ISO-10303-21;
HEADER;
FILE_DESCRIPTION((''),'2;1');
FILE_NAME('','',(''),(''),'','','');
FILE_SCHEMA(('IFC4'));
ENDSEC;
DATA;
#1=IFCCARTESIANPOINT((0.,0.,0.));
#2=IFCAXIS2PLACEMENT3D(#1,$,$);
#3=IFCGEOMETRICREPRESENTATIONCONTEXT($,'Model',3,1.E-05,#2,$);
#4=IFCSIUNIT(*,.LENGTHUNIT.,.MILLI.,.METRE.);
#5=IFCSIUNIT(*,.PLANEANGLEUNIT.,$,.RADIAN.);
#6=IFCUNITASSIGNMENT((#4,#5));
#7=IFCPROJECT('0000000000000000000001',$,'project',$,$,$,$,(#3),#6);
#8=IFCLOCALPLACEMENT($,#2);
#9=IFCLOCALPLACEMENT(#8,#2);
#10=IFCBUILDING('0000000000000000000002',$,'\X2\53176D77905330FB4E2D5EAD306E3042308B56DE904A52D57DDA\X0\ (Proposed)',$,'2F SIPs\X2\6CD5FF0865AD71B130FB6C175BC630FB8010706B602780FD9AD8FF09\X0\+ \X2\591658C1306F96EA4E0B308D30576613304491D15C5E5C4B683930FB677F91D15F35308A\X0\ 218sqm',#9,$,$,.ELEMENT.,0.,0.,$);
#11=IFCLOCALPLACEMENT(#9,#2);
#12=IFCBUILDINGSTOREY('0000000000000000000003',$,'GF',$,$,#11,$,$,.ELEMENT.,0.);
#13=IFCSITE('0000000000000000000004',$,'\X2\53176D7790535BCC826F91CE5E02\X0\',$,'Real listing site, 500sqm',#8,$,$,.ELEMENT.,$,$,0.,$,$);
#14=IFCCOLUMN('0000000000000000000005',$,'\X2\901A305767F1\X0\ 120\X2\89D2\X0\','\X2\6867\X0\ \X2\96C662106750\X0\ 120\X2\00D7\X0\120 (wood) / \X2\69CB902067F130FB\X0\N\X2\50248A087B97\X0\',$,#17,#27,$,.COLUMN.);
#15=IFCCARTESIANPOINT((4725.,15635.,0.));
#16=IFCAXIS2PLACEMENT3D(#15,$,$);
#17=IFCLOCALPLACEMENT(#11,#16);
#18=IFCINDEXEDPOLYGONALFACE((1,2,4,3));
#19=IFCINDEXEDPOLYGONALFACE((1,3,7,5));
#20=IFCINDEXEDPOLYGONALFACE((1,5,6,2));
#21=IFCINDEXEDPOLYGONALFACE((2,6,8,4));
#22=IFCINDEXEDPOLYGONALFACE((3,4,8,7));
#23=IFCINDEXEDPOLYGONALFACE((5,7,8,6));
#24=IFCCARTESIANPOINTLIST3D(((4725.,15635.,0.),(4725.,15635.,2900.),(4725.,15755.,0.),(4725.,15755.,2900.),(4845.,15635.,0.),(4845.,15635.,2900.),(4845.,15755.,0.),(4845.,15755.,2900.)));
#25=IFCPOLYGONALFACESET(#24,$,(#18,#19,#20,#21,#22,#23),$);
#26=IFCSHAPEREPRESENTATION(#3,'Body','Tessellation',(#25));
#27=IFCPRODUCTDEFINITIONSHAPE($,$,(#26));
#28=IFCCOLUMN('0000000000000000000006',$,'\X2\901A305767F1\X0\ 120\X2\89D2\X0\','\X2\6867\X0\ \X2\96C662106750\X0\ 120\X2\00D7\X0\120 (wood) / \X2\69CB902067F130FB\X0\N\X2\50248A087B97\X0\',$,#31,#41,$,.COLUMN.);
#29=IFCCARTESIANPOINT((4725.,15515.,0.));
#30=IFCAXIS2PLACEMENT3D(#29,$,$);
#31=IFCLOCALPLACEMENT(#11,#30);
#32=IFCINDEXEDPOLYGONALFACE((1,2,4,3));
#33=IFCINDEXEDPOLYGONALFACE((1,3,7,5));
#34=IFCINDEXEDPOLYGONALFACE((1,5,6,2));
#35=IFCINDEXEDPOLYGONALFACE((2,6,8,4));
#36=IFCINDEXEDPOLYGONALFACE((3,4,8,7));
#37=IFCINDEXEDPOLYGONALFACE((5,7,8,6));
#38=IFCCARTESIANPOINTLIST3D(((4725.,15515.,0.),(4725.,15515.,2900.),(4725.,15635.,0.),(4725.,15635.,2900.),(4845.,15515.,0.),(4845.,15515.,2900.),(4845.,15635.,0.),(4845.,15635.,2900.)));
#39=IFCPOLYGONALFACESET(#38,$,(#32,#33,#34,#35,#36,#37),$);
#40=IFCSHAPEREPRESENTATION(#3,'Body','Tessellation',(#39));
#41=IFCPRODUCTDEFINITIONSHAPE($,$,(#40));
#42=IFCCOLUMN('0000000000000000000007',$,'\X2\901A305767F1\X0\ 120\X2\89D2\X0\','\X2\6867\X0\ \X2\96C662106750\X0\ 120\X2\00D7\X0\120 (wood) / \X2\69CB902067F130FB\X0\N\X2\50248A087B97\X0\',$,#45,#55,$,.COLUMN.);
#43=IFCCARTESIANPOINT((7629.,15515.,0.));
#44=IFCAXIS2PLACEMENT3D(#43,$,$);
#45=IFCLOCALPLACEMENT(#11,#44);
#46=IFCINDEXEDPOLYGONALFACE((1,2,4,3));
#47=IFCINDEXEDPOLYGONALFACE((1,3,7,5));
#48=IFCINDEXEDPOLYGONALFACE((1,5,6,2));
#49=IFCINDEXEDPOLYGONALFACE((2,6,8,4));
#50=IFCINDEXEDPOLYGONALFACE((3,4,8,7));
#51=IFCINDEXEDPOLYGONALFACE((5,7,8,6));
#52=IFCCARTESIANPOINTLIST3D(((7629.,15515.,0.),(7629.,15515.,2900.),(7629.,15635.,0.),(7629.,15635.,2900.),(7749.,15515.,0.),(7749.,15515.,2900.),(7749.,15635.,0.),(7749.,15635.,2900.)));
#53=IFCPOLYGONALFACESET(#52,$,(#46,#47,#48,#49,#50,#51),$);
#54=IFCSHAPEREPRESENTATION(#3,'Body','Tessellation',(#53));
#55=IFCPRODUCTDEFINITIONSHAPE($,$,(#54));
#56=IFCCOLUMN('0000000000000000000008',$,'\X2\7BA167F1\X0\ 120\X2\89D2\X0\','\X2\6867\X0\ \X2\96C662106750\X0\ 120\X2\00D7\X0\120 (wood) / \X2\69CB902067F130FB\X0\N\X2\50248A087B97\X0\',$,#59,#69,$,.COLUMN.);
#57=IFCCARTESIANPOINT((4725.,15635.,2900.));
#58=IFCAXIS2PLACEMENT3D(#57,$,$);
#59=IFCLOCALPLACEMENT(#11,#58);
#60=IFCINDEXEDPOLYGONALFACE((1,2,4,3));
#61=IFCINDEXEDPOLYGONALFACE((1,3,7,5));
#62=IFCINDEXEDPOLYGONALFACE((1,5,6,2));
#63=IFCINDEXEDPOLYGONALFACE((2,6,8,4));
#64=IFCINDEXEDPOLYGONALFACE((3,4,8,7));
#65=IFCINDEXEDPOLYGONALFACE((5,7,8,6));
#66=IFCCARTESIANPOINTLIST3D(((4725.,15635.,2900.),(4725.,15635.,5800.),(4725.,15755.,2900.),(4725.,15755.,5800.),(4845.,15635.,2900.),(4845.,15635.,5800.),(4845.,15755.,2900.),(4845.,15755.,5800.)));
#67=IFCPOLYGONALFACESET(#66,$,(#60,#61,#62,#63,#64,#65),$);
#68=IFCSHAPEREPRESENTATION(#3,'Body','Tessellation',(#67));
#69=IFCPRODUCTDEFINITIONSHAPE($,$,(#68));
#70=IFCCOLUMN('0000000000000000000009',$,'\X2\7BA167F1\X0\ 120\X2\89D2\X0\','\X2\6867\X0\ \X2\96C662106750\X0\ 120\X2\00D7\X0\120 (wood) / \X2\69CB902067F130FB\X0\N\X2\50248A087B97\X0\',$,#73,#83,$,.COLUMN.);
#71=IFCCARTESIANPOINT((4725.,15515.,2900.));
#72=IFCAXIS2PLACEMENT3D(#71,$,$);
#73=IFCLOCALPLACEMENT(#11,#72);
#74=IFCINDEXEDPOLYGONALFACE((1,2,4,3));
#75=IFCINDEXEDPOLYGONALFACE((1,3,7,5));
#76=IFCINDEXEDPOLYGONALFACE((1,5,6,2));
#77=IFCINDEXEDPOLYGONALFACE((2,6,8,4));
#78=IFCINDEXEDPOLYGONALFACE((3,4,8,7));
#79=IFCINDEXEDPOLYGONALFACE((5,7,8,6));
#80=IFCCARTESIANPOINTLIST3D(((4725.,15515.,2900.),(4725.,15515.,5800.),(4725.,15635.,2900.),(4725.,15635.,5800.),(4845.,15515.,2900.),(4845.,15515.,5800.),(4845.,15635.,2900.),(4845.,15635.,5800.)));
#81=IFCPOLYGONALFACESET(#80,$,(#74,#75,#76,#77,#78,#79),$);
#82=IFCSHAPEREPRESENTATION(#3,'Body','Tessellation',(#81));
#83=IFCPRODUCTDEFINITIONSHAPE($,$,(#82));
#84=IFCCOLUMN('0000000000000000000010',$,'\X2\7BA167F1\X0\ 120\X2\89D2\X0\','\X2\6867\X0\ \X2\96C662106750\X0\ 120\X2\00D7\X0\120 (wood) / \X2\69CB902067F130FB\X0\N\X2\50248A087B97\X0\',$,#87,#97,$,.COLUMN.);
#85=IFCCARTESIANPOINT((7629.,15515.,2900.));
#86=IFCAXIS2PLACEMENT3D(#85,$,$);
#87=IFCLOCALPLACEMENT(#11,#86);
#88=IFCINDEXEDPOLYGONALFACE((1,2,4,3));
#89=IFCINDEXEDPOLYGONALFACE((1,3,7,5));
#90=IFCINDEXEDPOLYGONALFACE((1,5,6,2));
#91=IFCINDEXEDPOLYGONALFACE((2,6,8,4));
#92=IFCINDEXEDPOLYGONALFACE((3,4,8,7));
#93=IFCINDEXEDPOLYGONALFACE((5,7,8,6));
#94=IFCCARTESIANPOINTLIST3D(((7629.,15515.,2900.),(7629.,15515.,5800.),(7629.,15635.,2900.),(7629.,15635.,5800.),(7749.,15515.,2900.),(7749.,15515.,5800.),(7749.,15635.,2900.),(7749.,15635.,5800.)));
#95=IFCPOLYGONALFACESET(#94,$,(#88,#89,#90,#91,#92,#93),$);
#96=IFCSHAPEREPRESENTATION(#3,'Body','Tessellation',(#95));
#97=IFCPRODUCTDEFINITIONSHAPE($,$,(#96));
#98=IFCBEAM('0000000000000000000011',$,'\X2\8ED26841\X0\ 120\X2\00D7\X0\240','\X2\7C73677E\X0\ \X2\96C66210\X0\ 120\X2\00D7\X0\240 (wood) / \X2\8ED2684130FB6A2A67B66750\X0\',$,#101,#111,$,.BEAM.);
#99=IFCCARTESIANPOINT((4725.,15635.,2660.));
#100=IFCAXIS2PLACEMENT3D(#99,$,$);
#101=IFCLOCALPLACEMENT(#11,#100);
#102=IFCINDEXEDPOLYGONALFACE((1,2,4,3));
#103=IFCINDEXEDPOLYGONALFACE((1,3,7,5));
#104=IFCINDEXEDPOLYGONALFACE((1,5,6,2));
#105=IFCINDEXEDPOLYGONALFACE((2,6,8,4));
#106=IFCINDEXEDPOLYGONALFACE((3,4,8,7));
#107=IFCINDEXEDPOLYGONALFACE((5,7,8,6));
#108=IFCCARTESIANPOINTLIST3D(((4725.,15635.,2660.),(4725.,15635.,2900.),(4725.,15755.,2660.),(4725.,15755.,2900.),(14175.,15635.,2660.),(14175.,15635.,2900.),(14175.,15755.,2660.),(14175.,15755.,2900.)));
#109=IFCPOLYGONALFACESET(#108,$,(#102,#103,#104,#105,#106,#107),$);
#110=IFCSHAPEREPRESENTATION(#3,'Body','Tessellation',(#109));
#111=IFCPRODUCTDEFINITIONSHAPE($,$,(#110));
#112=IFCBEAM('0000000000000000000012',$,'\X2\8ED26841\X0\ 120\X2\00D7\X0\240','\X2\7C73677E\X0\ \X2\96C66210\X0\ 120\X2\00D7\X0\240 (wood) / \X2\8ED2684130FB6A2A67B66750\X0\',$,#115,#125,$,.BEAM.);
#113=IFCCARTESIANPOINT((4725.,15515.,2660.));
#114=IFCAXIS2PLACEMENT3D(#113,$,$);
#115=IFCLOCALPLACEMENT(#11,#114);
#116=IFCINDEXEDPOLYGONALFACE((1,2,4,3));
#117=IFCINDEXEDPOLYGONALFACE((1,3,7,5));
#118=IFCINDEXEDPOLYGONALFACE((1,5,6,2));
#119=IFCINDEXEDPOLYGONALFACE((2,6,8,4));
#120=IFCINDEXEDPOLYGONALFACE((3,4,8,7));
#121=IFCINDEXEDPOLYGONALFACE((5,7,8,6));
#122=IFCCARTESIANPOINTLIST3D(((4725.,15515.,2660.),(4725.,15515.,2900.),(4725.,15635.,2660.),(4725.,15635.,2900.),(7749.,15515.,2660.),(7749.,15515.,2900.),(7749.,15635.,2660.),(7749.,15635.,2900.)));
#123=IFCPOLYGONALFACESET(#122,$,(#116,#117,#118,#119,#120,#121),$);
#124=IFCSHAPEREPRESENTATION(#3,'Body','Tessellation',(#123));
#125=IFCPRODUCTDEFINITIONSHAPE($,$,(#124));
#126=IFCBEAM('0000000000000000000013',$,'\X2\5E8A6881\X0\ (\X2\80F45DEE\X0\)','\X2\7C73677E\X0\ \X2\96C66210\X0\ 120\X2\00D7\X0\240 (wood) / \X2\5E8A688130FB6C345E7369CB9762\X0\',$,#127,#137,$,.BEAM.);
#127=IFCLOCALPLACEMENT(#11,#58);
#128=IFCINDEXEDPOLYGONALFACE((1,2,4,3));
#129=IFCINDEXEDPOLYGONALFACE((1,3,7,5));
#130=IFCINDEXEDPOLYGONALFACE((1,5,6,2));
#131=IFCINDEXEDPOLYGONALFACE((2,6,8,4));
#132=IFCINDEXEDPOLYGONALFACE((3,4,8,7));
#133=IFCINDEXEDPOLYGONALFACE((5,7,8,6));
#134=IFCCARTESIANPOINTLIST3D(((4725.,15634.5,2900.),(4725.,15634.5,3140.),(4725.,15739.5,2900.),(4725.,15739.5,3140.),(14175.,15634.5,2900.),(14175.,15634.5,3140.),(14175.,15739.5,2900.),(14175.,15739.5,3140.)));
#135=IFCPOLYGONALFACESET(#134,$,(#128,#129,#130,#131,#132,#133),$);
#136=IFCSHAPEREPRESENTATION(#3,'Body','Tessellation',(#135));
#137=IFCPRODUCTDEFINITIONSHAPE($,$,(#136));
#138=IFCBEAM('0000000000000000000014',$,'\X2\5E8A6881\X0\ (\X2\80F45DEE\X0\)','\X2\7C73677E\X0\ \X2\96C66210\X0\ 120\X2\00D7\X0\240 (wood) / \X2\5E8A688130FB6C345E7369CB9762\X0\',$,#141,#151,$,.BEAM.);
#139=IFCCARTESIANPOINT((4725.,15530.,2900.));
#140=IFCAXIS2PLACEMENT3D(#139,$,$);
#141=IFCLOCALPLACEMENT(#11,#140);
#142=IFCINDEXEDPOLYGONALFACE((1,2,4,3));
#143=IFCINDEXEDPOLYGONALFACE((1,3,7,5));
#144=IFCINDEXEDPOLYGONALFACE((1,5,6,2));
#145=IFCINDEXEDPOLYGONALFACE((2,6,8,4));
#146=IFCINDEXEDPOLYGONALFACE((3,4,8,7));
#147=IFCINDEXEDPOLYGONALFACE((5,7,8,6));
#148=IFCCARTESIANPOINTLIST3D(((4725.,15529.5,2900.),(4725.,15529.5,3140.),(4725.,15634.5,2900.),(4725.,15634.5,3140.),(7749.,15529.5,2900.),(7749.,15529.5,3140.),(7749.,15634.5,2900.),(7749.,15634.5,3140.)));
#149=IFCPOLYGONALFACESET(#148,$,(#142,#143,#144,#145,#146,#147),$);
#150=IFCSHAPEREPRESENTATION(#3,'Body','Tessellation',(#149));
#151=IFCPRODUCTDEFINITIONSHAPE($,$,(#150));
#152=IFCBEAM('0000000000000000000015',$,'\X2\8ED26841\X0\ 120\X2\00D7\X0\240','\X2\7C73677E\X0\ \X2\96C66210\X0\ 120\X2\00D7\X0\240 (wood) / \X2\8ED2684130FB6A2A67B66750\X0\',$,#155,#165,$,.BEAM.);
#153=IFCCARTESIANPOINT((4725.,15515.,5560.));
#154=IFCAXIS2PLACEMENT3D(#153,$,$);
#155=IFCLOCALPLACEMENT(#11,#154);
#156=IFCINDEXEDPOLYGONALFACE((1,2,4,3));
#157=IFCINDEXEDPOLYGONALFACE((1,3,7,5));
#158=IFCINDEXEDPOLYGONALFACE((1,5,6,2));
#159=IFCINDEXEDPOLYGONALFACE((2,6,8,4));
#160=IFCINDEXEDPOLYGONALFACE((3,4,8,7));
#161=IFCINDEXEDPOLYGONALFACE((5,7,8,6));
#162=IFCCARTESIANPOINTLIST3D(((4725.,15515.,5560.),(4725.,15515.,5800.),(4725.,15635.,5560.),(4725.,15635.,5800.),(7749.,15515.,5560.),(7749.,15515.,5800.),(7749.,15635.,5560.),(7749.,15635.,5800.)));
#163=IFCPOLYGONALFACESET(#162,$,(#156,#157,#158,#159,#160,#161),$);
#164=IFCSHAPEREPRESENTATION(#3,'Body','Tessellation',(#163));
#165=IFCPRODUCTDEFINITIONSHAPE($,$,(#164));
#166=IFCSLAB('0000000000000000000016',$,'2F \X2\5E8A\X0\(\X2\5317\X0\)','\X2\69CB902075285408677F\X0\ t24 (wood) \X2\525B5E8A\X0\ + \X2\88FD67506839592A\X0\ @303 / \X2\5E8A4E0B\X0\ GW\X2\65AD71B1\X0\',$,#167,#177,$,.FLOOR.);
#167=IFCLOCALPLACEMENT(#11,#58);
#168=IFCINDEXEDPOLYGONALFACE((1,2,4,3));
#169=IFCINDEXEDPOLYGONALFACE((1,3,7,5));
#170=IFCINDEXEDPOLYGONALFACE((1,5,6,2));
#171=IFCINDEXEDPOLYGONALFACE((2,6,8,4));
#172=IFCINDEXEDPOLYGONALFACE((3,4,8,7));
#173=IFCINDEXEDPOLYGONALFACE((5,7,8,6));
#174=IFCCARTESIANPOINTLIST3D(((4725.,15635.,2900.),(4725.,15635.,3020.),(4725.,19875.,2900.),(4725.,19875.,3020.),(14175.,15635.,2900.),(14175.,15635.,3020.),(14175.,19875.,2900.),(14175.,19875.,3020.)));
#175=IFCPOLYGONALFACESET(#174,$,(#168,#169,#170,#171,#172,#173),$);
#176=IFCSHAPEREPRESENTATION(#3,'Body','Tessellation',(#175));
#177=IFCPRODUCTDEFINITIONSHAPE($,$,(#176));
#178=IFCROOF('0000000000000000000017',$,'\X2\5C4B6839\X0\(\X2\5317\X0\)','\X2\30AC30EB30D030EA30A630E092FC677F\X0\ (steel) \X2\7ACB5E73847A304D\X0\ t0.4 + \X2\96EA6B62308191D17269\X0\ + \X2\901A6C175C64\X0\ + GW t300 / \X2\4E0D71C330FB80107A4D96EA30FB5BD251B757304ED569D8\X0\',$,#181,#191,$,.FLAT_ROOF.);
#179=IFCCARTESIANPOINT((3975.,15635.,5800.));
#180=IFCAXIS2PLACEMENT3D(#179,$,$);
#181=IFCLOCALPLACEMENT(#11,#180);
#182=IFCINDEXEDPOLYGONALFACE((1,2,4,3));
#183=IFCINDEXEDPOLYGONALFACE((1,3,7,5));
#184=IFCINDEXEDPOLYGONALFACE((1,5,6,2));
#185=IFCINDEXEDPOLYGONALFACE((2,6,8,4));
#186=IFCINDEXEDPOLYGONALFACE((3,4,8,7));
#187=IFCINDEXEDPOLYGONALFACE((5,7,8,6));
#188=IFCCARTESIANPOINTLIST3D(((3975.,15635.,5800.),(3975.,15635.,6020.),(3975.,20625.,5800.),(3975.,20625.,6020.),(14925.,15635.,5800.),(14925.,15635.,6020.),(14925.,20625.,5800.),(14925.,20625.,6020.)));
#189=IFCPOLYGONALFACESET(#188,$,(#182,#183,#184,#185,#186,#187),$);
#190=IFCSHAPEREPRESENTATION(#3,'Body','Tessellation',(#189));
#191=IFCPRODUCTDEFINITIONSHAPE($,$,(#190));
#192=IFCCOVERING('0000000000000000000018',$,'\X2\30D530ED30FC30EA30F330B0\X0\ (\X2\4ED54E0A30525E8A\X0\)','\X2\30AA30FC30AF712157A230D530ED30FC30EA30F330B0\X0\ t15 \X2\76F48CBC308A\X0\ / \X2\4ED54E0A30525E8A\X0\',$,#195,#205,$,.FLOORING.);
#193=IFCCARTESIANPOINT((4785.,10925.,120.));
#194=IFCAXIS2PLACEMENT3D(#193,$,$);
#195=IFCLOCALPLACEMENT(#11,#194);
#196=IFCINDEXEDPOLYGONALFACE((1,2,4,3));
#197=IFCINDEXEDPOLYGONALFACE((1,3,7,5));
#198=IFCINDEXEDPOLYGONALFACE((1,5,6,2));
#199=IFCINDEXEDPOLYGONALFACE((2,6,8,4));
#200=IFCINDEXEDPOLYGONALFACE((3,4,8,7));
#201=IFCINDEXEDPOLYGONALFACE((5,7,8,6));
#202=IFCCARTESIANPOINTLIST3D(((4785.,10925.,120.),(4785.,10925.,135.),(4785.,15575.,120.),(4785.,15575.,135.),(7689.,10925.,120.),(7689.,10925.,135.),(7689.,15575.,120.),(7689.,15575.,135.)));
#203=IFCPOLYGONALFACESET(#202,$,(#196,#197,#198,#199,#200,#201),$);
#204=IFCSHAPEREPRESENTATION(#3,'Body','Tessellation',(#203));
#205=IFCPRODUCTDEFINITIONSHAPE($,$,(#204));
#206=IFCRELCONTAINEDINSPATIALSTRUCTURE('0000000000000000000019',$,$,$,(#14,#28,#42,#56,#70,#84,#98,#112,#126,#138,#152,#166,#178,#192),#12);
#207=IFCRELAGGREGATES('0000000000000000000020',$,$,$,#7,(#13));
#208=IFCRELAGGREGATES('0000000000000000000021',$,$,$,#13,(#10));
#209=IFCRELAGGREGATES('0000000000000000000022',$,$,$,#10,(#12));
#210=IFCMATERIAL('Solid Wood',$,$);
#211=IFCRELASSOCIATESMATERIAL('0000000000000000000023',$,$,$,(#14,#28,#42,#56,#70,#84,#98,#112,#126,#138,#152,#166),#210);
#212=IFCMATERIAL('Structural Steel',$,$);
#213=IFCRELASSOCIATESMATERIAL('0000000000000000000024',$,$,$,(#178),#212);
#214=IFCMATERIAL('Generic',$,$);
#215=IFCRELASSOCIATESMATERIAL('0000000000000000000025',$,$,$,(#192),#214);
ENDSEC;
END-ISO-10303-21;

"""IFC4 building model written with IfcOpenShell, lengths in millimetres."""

from ifc_helpers import new_model, si_unit, frame, frame_2d, origin, place, context, project, spatial, rectangle, extrude, material, element, save


model = new_model("IFC4")

# Units and contexts
model_context = context("Model", 3, precision=1e-05, world=origin())
ifc_project = project(units=[si_unit("LENGTHUNIT", "METRE", prefix="MILLI"), si_unit("PLANEANGLEUNIT", "RADIAN")], contexts=[model_context])

# Site, building, storey
site_placement = place(None, origin())
site = spatial("IfcSite", under=ifc_project, at=site_placement, Name="北海道富良野市", ObjectType="Real listing site, 500sqm", CompositionType="ELEMENT", RefElevation=0.0)
building_placement = place(site_placement, origin())
building = spatial("IfcBuilding", under=site, at=building_placement, Name="北海道・中庭のある回遊動線 (Proposed)", ObjectType="2F SIPs法（断熱・気密・耐火性能高）+ 外壁は雪下ろし易い金属屋根・板金張り 218sqm", CompositionType="ELEMENT", ElevationOfRefHeight=0.0, ElevationOfTerrain=0.0)
storey_placement = place(building_placement, origin())
storey = spatial("IfcBuildingStorey", under=building, at=storey_placement, Name="GF", CompositionType="ELEMENT", Elevation=0.0)

# Columns
ifc_material_1 = material(Name="Solid Wood")
column_1_placement = place(storey_placement, frame((4725.0, 15635.0, 0.0)))
element("IfcColumn", 1, at=column_1_placement, inside=storey, material=ifc_material_1, Name="通し柱 120角", Description="桧 集成材 120×120 (wood) / 構造柱・N値計算", PredefinedType="COLUMN", context=model_context, shape_type="SweptSolid", body=[
    extrude(rectangle(XDim=120.0, YDim=120.0, at=frame_2d((60.0, 60.0))), frame((4725.0, 15635.0, 0.0)), (0.0, 0.0, 1.0), 2900.0),
])
column_2_placement = place(storey_placement, frame((4725.0, 15515.0, 0.0)))
element("IfcColumn", 2, at=column_2_placement, inside=storey, material=ifc_material_1, Name="通し柱 120角", Description="桧 集成材 120×120 (wood) / 構造柱・N値計算", PredefinedType="COLUMN", context=model_context, shape_type="SweptSolid", body=[
    extrude(rectangle(XDim=120.0, YDim=120.0, at=frame_2d((60.0, 60.0))), frame((4725.0, 15515.0, 0.0)), (0.0, 0.0, 1.0), 2900.0),
])
column_3_placement = place(storey_placement, frame((7629.0, 15515.0, 0.0)))
element("IfcColumn", 3, at=column_3_placement, inside=storey, material=ifc_material_1, Name="通し柱 120角", Description="桧 集成材 120×120 (wood) / 構造柱・N値計算", PredefinedType="COLUMN", context=model_context, shape_type="SweptSolid", body=[
    extrude(rectangle(XDim=120.0, YDim=120.0, at=frame_2d((60.0, 60.0))), frame((7629.0, 15515.0, 0.0)), (0.0, 0.0, 1.0), 2900.0),
])
column_4_placement = place(storey_placement, frame((4725.0, 15635.0, 2900.0)))
element("IfcColumn", 4, at=column_4_placement, inside=storey, material=ifc_material_1, Name="管柱 120角", Description="桧 集成材 120×120 (wood) / 構造柱・N値計算", PredefinedType="COLUMN", context=model_context, shape_type="SweptSolid", body=[
    extrude(rectangle(XDim=120.0, YDim=120.0, at=frame_2d((60.0, 60.0))), frame((4725.0, 15635.0, 2900.0)), (0.0, 0.0, 1.0), 2900.0),
])
column_5_placement = place(storey_placement, frame((4725.0, 15515.0, 2900.0)))
element("IfcColumn", 5, at=column_5_placement, inside=storey, material=ifc_material_1, Name="管柱 120角", Description="桧 集成材 120×120 (wood) / 構造柱・N値計算", PredefinedType="COLUMN", context=model_context, shape_type="SweptSolid", body=[
    extrude(rectangle(XDim=120.0, YDim=120.0, at=frame_2d((60.0, 60.0))), frame((4725.0, 15515.0, 2900.0)), (0.0, 0.0, 1.0), 2900.0),
])
column_6_placement = place(storey_placement, frame((7629.0, 15515.0, 2900.0)))
element("IfcColumn", 6, at=column_6_placement, inside=storey, material=ifc_material_1, Name="管柱 120角", Description="桧 集成材 120×120 (wood) / 構造柱・N値計算", PredefinedType="COLUMN", context=model_context, shape_type="SweptSolid", body=[
    extrude(rectangle(XDim=120.0, YDim=120.0, at=frame_2d((60.0, 60.0))), frame((7629.0, 15515.0, 2900.0)), (0.0, 0.0, 1.0), 2900.0),
])

# Beams
beam_1_placement = place(storey_placement, frame((4725.0, 15635.0, 2660.0)))
element("IfcBeam", 7, at=beam_1_placement, inside=storey, material=ifc_material_1, Name="軒桁 120×240", Description="米松 集成 120×240 (wood) / 軒桁・横架材", PredefinedType="BEAM", context=model_context, shape_type="SweptSolid", body=[
    extrude(rectangle(XDim=9450.0, YDim=120.0, at=frame_2d((4725.0, 60.0))), frame((4725.0, 15635.0, 2660.0)), (0.0, 0.0, 1.0), 240.0),
])
beam_2_placement = place(storey_placement, frame((4725.0, 15515.0, 2660.0)))
element("IfcBeam", 8, at=beam_2_placement, inside=storey, material=ifc_material_1, Name="軒桁 120×240", Description="米松 集成 120×240 (wood) / 軒桁・横架材", PredefinedType="BEAM", context=model_context, shape_type="SweptSolid", body=[
    extrude(rectangle(XDim=3024.0, YDim=120.0, at=frame_2d((1512.0, 60.0))), frame((4725.0, 15515.0, 2660.0)), (0.0, 0.0, 1.0), 240.0),
])
beam_3_placement = place(storey_placement, frame((4725.0, 15635.0, 2900.0)))
element("IfcBeam", 9, at=beam_3_placement, inside=storey, material=ifc_material_1, Name="床梁 (胴差)", Description="米松 集成 120×240 (wood) / 床梁・水平構面", PredefinedType="BEAM", context=model_context, shape_type="SweptSolid", body=[
    extrude(rectangle(XDim=9450.0, YDim=105.0, at=frame_2d((4725.0, 52.0))), frame((4725.0, 15635.0, 2900.0)), (0.0, 0.0, 1.0), 240.0),
])
beam_4_placement = place(storey_placement, frame((4725.0, 15530.0, 2900.0)))
element("IfcBeam", 10, at=beam_4_placement, inside=storey, material=ifc_material_1, Name="床梁 (胴差)", Description="米松 集成 120×240 (wood) / 床梁・水平構面", PredefinedType="BEAM", context=model_context, shape_type="SweptSolid", body=[
    extrude(rectangle(XDim=3024.0, YDim=105.0, at=frame_2d((1512.0, 52.0))), frame((4725.0, 15530.0, 2900.0)), (0.0, 0.0, 1.0), 240.0),
])
beam_5_placement = place(storey_placement, frame((4725.0, 15515.0, 5560.0)))
element("IfcBeam", 11, at=beam_5_placement, inside=storey, material=ifc_material_1, Name="軒桁 120×240", Description="米松 集成 120×240 (wood) / 軒桁・横架材", PredefinedType="BEAM", context=model_context, shape_type="SweptSolid", body=[
    extrude(rectangle(XDim=3024.0, YDim=120.0, at=frame_2d((1512.0, 60.0))), frame((4725.0, 15515.0, 5560.0)), (0.0, 0.0, 1.0), 240.0),
])

# Slab
slab_1_placement = place(storey_placement, frame((4725.0, 15635.0, 2900.0)))
element("IfcSlab", 12, at=slab_1_placement, inside=storey, material=ifc_material_1, Name="2F 床(北)", Description="構造用合板 t24 (wood) 剛床 + 製材根太 @303 / 床下 GW断熱", PredefinedType="FLOOR", context=model_context, shape_type="SweptSolid", body=[
    extrude(rectangle(XDim=9450.0, YDim=4240.0, at=frame_2d((4725.0, 2120.0))), frame((4725.0, 15635.0, 2900.0)), (0.0, 0.0, 1.0), 120.0),
])

# Roof
ifc_material_2 = material(Name="Structural Steel")
for number, where, name in (
    (13, (3975.0, 15635.0, 5800.0), "屋根(北)"),
):
    element("IfcRoof", number, at=place(storey_placement, frame(where)), inside=storey, material=ifc_material_2, Name=name, Description="ガルバリウム鋼板 (steel) 立平葺き t0.4 + 雪止め金物 + 通気層 + GW t300 / 不燃・耐積雪・寒冷地仕様", PredefinedType="FLAT_ROOF", context=model_context, shape_type="SweptSolid", body=[
        extrude(rectangle(XDim=10950.0, YDim=4990.0, at=frame_2d((5475.0, 2495.0))), frame((3975.0, 15635.0, 5800.0)), (0.0, 0.0, 1.0), 220.0),
    ])

# Covering
ifc_material_3 = material(Name="Generic")
covering_1_placement = place(storey_placement, frame((4785.0, 10925.0, 120.0)))
element("IfcCovering", 14, at=covering_1_placement, inside=storey, material=ifc_material_3, Name="フローリング (仕上げ床)", Description="オーク無垢フローリング t15 直貼り / 仕上げ床", PredefinedType="FLOORING", context=model_context, shape_type="SweptSolid", body=[
    extrude(rectangle(XDim=2904.0, YDim=4650.0, at=frame_2d((1452.0, 2325.0))), frame((4785.0, 10925.0, 120.0)), (0.0, 0.0, 1.0), 15.0),
])

save(model, "model.ifc")
